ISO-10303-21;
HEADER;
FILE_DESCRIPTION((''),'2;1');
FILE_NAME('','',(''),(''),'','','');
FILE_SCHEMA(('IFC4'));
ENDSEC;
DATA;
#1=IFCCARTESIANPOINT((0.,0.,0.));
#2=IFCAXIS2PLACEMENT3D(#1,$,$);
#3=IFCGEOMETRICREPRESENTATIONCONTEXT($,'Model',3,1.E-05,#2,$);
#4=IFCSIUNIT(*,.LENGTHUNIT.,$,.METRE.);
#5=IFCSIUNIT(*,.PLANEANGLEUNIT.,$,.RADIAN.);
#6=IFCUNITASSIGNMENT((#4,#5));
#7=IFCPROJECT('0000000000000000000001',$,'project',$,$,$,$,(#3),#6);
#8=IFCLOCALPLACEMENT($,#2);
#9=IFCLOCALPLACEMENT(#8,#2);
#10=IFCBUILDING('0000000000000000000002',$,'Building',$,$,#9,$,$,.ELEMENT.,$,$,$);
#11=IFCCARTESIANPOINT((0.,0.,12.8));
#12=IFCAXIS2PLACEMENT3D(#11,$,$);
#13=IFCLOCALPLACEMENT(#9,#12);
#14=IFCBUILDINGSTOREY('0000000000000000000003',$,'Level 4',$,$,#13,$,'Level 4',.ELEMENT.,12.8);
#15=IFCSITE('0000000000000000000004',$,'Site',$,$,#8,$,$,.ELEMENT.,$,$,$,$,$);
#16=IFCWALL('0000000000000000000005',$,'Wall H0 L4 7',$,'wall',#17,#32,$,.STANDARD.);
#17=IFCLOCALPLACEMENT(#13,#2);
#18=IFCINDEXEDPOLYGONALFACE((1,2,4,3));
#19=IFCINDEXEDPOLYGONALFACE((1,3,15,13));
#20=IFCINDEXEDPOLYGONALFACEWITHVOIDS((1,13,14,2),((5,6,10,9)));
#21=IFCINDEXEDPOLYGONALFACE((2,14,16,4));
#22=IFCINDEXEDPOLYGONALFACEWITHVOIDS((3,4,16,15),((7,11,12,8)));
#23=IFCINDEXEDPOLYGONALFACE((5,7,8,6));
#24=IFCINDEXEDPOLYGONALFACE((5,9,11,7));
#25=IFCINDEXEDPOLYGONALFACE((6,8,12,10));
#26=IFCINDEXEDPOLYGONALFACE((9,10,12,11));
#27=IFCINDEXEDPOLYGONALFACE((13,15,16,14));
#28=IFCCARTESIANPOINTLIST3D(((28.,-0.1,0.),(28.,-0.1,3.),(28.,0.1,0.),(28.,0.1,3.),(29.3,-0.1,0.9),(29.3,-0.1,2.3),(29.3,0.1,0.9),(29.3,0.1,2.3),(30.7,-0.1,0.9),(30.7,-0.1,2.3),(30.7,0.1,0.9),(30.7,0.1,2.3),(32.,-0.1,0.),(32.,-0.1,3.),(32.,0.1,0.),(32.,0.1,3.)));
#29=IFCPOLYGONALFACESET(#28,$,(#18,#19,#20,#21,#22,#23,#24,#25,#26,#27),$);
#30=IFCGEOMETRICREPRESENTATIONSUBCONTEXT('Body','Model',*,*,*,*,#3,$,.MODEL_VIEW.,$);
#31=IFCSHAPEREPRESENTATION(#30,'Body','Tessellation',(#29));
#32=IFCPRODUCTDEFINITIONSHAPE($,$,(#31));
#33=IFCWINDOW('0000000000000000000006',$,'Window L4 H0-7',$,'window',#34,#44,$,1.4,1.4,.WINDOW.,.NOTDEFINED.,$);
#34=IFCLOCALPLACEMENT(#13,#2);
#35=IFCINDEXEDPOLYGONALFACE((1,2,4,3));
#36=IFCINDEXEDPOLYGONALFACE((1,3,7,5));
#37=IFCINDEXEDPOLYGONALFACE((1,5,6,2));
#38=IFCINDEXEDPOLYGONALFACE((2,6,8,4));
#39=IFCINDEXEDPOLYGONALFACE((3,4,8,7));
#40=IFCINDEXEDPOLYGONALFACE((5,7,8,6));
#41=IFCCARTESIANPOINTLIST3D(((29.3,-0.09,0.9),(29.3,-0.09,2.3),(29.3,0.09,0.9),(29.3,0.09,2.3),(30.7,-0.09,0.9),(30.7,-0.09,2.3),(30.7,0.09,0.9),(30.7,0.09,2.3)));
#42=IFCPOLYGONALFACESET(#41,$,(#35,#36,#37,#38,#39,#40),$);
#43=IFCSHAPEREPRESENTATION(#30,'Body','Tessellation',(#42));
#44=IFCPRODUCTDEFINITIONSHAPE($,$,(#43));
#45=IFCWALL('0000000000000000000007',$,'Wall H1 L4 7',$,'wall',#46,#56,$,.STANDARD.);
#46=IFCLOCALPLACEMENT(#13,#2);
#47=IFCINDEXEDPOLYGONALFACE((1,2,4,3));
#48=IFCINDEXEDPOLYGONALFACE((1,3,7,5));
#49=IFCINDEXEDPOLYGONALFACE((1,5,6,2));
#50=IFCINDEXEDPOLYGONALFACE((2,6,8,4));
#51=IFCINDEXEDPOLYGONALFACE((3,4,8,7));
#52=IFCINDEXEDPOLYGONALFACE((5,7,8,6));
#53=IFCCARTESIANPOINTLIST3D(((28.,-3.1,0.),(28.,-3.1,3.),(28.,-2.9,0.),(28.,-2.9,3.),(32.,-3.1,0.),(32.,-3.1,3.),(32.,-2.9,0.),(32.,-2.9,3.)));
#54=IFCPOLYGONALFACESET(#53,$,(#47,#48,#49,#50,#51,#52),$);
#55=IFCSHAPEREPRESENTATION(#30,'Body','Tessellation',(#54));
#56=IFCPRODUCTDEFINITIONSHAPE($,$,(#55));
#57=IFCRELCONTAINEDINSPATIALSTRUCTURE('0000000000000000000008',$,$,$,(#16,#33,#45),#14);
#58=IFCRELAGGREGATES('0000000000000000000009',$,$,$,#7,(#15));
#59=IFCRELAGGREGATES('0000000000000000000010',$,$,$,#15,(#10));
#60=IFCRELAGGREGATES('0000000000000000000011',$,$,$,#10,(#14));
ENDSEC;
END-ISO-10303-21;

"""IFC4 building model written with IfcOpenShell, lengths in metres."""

from ifc_helpers import new_model, si_unit, frame, frame_2d, origin, origin_2d, place, context, subcontext, project, spatial, rectangle, extrude, element, fill, save


model = new_model("IFC4")

# Units and contexts
model_context = context("Model", 3, precision=1e-05, world=origin())
body_context = subcontext(model_context, "Body", "Model", "MODEL_VIEW")
ifc_project = project(units=[si_unit("LENGTHUNIT", "METRE"), si_unit("PLANEANGLEUNIT", "RADIAN")], contexts=[model_context])

# Site, building, storey
site_placement = place(None, origin())
site = spatial("IfcSite", under=ifc_project, at=site_placement, Name="Site", CompositionType="ELEMENT")
building_placement = place(site_placement, origin())
building = spatial("IfcBuilding", under=site, at=building_placement, Name="Building", CompositionType="ELEMENT")
storey_placement = place(building_placement, frame((0.0, 0.0, 12.8)))
storey = spatial("IfcBuildingStorey", under=building, at=storey_placement, Name="Level 4", LongName="Level 4", CompositionType="ELEMENT", Elevation=12.8)

# Wall, opening, window
wall_1_placement = place(storey_placement, frame((28.0, 0.0, 0.0), z_axis=(0.0, 0.0, 1.0), x_axis=(1.0, 0.0, 0.0)))
wall_1 = element("IfcWall", 1, at=wall_1_placement, inside=storey, Name="Wall H0 L4 7", ObjectType="wall", PredefinedType="STANDARD", context=body_context, shape_type="SweptSolid", body=[
    extrude(rectangle(XDim=4.0, YDim=0.2, at=frame_2d((2.0, 0.0))), origin(), (0.0, 0.0, 1.0), 3.0),
])
opening_1_placement = place(storey_placement, frame((30.0, 0.0, 0.9), z_axis=(0.0, 0.0, 1.0), x_axis=(1.0, 0.0, 0.0)))
opening_1 = element("IfcOpeningElement", 2, at=opening_1_placement, cuts=wall_1, ObjectType="Opening", PredefinedType="OPENING", context=body_context, shape_type="SweptSolid", body=[
    extrude(rectangle(XDim=1.4, YDim=0.22, at=origin_2d()), origin(), (0.0, 0.0, 1.0), 1.4),
])
window_1_placement = place(storey_placement, frame((30.0, 0.0, 0.9), z_axis=(0.0, 0.0, 1.0), x_axis=(1.0, 0.0, 0.0)))
window_1 = element("IfcWindow", 3, at=window_1_placement, inside=storey, Name="Window L4 H0-7", ObjectType="window", OverallHeight=1.4, OverallWidth=1.4, PartitioningType="NOTDEFINED", PredefinedType="WINDOW", context=body_context, shape_type="SweptSolid", body=[
    extrude(rectangle(XDim=1.4, YDim=0.18, at=origin_2d()), origin(), (0.0, 0.0, 1.0), 1.4),
])
fill(opening_1, window_1)

# Wall
wall_2_placement = place(storey_placement, frame((28.0, -3.0, 0.0), z_axis=(0.0, 0.0, 1.0), x_axis=(1.0, 0.0, 0.0)))
element("IfcWall", 4, at=wall_2_placement, inside=storey, Name="Wall H1 L4 7", ObjectType="wall", PredefinedType="STANDARD", context=body_context, shape_type="SweptSolid", body=[
    extrude(rectangle(XDim=4.0, YDim=0.2, at=frame_2d((2.0, 0.0))), origin(), (0.0, 0.0, 1.0), 3.0),
])

save(model, "model.ifc")
